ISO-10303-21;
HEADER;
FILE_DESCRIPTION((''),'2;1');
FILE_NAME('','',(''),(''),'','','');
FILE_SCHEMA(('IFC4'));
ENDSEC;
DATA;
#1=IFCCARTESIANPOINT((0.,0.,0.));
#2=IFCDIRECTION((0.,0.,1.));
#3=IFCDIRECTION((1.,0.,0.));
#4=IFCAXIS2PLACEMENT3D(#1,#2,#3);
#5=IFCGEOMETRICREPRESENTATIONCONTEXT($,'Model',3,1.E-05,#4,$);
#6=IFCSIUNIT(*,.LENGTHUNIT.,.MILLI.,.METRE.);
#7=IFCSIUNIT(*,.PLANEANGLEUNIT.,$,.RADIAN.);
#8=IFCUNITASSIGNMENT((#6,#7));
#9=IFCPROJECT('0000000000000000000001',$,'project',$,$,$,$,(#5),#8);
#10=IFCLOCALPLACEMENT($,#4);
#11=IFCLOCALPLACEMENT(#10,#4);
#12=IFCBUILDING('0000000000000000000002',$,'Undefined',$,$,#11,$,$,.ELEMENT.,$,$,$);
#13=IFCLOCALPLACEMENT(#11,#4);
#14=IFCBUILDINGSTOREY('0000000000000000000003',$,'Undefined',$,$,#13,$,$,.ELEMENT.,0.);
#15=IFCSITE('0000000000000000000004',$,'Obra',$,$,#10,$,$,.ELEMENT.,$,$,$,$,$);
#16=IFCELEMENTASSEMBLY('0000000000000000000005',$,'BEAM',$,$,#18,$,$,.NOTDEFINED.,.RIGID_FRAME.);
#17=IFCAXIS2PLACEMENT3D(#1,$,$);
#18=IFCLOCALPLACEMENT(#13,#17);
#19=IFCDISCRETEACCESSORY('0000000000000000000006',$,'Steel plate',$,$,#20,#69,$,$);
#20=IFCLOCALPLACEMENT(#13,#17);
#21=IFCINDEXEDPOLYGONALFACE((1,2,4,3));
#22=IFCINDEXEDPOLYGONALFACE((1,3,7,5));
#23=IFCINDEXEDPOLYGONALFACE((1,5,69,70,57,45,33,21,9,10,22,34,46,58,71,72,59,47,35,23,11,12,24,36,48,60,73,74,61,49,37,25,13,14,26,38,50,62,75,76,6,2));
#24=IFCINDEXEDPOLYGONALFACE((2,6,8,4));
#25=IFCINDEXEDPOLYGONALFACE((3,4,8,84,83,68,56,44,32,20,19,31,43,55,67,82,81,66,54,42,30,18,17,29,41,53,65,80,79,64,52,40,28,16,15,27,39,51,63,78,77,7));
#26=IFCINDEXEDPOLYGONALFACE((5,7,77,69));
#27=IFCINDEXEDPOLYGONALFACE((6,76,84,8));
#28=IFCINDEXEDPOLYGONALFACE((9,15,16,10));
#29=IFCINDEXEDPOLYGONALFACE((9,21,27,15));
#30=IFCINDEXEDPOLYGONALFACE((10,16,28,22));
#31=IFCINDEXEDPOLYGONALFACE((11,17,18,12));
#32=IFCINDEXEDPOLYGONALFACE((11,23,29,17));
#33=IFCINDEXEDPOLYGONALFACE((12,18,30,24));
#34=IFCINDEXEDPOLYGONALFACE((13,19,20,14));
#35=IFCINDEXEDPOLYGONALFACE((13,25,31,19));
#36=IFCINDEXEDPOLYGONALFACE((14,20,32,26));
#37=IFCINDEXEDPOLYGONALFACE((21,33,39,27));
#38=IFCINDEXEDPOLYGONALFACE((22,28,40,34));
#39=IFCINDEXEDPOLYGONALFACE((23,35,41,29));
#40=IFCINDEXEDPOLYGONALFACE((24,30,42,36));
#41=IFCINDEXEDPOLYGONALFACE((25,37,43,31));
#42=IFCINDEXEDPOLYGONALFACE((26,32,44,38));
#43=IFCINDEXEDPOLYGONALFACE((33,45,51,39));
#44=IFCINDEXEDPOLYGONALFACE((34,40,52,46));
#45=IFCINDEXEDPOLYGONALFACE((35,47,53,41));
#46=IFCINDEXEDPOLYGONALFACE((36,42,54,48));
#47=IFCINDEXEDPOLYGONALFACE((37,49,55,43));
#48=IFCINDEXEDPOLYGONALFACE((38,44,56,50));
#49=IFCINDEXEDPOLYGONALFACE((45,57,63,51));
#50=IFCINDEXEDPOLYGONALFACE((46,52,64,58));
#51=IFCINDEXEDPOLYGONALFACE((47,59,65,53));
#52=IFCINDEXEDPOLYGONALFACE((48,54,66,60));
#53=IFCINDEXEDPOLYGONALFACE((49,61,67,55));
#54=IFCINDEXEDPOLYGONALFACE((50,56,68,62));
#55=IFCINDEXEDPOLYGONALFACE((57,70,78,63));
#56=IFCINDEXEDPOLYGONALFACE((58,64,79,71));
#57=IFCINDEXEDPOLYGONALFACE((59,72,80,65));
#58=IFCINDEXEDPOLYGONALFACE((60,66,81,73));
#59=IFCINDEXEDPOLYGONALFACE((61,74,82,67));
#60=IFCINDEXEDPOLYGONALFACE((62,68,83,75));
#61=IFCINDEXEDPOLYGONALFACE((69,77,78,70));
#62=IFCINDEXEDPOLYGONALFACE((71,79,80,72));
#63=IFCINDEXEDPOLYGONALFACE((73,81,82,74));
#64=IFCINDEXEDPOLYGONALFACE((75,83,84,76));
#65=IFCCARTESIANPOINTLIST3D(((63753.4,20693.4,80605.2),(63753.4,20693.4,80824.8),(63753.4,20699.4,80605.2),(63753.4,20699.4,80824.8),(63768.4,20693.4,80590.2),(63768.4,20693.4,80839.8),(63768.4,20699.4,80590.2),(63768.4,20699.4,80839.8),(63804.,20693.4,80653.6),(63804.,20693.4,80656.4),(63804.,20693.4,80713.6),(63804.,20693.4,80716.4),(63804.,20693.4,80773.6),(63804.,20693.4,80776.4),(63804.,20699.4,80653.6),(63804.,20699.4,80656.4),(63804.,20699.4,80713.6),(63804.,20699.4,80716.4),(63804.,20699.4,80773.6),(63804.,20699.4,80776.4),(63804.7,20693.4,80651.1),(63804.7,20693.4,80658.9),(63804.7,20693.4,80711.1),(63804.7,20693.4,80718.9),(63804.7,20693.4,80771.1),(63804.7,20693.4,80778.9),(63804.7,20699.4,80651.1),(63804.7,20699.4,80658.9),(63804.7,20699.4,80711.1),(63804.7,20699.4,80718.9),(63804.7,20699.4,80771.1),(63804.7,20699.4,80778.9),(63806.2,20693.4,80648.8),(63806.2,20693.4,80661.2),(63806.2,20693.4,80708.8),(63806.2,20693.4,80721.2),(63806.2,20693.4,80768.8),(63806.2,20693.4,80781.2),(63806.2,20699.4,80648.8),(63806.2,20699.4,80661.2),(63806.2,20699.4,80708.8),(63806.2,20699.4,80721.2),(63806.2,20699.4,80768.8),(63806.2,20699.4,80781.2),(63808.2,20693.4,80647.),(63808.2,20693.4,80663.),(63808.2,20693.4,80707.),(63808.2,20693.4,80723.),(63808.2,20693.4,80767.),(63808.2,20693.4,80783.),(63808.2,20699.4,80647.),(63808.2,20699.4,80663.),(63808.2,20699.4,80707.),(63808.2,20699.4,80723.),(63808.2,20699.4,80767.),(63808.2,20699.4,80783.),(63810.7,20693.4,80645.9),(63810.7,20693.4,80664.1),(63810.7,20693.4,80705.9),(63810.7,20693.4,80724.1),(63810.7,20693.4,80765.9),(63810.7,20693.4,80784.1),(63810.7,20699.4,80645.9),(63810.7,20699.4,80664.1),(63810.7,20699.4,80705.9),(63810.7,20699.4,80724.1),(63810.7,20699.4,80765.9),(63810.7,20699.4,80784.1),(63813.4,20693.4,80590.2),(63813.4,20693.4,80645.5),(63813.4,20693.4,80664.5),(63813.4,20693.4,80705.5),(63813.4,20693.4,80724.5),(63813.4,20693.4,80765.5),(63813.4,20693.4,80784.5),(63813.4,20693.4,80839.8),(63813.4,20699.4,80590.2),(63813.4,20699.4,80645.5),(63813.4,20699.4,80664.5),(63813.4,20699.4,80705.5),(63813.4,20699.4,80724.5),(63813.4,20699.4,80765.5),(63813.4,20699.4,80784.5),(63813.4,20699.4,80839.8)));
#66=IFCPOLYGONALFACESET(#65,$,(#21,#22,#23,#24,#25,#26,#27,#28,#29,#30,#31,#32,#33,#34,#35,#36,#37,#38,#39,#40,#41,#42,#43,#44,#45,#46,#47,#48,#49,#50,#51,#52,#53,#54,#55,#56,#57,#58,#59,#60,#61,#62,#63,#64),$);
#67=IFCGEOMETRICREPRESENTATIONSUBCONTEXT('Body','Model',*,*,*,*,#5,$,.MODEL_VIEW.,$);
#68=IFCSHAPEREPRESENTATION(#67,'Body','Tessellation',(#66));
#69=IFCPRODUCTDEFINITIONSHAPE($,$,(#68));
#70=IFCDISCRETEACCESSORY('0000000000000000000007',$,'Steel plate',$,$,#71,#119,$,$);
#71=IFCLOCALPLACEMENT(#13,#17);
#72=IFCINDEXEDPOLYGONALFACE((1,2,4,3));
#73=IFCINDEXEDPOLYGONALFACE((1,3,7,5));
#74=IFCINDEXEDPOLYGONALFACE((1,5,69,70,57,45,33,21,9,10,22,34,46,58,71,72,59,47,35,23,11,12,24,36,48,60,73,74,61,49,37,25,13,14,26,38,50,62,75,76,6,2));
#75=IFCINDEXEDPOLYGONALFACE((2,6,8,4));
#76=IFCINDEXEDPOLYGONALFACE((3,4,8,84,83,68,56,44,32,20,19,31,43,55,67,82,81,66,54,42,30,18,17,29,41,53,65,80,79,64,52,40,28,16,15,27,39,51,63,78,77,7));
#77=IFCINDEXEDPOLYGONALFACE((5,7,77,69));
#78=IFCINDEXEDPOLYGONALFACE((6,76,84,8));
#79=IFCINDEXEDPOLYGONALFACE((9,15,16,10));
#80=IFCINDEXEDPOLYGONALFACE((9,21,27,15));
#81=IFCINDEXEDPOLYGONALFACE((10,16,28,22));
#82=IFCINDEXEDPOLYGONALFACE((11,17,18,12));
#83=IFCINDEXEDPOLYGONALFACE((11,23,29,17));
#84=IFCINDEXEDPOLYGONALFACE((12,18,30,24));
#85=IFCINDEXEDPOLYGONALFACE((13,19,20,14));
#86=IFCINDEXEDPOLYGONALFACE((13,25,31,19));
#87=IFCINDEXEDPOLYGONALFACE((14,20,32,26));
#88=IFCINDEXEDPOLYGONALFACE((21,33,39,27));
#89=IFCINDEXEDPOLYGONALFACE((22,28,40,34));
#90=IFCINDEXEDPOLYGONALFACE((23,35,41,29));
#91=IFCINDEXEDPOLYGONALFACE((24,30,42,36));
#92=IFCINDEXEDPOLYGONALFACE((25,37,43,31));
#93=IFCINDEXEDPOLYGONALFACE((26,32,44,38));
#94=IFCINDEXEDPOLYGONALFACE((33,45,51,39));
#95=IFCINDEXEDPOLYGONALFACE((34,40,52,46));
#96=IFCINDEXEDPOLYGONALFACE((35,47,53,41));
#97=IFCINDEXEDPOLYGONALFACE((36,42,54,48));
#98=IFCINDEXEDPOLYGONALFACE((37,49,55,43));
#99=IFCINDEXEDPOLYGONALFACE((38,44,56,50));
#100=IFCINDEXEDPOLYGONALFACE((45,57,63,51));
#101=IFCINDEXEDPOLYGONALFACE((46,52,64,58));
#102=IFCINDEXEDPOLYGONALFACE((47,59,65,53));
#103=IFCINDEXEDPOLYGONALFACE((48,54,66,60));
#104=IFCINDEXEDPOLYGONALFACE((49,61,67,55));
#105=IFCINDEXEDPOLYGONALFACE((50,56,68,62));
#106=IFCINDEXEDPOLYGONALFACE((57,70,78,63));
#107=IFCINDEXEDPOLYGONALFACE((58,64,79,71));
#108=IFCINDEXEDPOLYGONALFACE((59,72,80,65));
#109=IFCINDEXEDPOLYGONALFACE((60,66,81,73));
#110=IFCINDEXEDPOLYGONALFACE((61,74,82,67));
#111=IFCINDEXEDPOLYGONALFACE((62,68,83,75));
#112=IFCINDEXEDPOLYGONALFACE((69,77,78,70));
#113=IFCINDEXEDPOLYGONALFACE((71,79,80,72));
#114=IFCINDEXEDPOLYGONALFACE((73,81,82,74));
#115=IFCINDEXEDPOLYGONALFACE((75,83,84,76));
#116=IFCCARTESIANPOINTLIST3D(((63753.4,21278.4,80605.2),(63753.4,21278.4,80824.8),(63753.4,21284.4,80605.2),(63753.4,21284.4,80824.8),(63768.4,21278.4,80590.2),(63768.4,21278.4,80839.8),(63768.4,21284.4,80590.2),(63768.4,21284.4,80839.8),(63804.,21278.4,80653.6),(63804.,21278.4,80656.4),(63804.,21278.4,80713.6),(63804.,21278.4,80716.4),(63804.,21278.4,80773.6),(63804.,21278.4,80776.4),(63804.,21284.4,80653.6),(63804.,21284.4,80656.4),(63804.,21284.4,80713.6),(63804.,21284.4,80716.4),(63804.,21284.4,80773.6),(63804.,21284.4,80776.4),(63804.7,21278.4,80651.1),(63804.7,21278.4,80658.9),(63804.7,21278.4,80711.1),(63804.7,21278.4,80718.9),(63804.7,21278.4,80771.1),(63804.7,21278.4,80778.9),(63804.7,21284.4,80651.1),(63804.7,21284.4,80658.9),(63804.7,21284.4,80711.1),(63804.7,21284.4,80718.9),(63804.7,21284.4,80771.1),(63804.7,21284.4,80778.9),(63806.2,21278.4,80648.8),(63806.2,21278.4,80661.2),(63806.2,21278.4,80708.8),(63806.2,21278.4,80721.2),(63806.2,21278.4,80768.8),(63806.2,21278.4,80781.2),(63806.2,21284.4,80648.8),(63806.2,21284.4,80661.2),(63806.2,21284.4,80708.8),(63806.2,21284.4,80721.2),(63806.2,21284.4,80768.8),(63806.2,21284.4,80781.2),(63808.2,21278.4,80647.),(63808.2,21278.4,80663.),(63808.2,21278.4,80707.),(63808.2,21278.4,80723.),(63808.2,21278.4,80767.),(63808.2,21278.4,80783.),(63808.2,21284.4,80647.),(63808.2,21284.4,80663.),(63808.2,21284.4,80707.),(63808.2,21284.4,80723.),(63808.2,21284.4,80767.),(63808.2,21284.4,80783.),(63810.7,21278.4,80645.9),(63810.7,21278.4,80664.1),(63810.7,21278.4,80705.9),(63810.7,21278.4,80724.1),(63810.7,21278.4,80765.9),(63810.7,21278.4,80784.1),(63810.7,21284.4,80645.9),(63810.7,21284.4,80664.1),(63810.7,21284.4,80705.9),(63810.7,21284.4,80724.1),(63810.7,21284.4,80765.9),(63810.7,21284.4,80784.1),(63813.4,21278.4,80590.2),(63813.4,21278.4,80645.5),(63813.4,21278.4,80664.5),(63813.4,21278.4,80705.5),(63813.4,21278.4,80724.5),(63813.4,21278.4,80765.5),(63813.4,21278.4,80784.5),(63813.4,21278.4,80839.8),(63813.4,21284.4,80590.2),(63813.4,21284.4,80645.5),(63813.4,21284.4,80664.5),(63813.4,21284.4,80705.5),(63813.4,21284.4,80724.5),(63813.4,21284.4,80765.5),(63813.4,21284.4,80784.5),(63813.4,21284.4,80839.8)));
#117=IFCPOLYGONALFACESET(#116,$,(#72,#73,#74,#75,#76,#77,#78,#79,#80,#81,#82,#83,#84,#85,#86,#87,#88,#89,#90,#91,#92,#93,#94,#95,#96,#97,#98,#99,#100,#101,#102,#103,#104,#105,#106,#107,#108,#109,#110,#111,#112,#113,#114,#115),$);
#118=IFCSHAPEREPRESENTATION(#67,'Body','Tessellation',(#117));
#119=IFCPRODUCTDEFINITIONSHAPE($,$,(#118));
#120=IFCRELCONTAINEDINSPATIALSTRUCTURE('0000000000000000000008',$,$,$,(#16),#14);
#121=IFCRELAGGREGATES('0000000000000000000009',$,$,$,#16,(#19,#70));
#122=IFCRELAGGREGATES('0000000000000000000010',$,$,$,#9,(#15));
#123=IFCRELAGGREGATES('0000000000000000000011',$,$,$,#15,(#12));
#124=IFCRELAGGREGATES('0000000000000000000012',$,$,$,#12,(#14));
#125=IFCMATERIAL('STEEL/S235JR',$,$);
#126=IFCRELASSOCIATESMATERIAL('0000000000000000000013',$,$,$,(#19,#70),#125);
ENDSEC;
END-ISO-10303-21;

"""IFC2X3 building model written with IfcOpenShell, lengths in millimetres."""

from ifc_helpers import new_model, si_unit, frame, origin_with_axes, origin_2d_with_axis, place, context, subcontext, project, spatial, polyline, circle, outline, extrude, source, transform, mapped, material, element, aggregate, save


model = new_model("IFC2X3")

# Units and contexts
model_context = context("Model", 3, precision=1e-05, world=origin_with_axes())
body_context = subcontext(model_context, "Body", "Model", "MODEL_VIEW")
ifc_project = project(units=[si_unit("LENGTHUNIT", "METRE", prefix="MILLI"), si_unit("PLANEANGLEUNIT", "RADIAN")], contexts=[model_context])

# Site, building, storey
site_placement = place(None, origin_with_axes())
site = spatial("IfcSite", under=ifc_project, at=site_placement, Name="Obra", CompositionType="ELEMENT")
building_placement = place(site_placement, origin_with_axes())
building = spatial("IfcBuilding", under=site, at=building_placement, Name="Undefined", CompositionType="ELEMENT")
storey_placement = place(building_placement, origin_with_axes())
storey = spatial("IfcBuildingStorey", under=building, at=storey_placement, Name="Undefined", CompositionType="ELEMENT", Elevation=0.0)

# Shared definitions
ifc_material = material(Name="STEEL/S235JR")

# Shared definitions
shared_shape_1 = source(origin_with_axes(), body_context, "Body", "SweptSolid", [
    extrude(circle(Radius=9.5, at=origin_2d_with_axis()), frame((0.0, -9.4, 0.0), z_axis=(0.0, 1.0, 0.0), x_axis=(1.0, 0.0, 0.0)), (0.0, 0.0, 1.0), 6.2),
])

# Element assembly, discrete accessories, openings
assembly_1_placement = place(storey_placement, origin_with_axes())
assembly_1 = element("IfcElementAssembly", 1, at=assembly_1_placement, inside=storey, Name="BEAM", AssemblyPlace="NOTDEFINED", PredefinedType="RIGID_FRAME")
discrete_accessory_1_placement = place(assembly_1_placement, frame((63813.4, 20696.4, 80590.2), z_axis=(0.0, 1.0, 0.0), x_axis=(-1.0, 0.0, 0.0)))
discrete_accessory_1 = element("IfcDiscreteAccessory", 2, at=discrete_accessory_1_placement, material=ifc_material, Name="Steel plate", context=body_context, shape_type="SweptSolid", body=[
    extrude(outline(polyline([(0.0, 0.0), (45.0, 0.0), (60.0, 15.0), (60.0, 234.6), (45.0, 249.6), (0.0, 249.6), (0.0, 0.0)])), frame((0.0, 0.0, -3.0), z_axis=(0.0, 0.0, 1.0), x_axis=(1.0, 0.0, 0.0)), (0.0, 0.0, 1.0), 6.0),
])
opening_1_placement = place(assembly_1_placement, frame((63763.4, 20702.7, 80850.0), z_axis=(1.0, 0.0, 0.0), x_axis=(0.0, 0.0, -1.0)))
element("IfcOpeningElement", 3, at=opening_1_placement, cuts=discrete_accessory_1, ObjectType="Opening", context=body_context, shape_type="MappedRepresentation", body=[
    mapped(shared_shape_1, transform((75.0, 0.0, 50.0))),
    mapped(shared_shape_1, transform((135.0, 0.0, 50.0))),
    mapped(shared_shape_1, transform((195.0, 0.0, 50.0))),
])
discrete_accessory_2_placement = place(assembly_1_placement, frame((63813.4, 21281.4, 80590.2), z_axis=(0.0, 1.0, 0.0), x_axis=(-1.0, 0.0, 0.0)))
discrete_accessory_2 = element("IfcDiscreteAccessory", 4, at=discrete_accessory_2_placement, material=ifc_material, Name="Steel plate", context=body_context, shape_type="SweptSolid", body=[
    extrude(outline(polyline([(0.0, 0.0), (45.0, 0.0), (60.0, 15.0), (60.0, 234.6), (45.0, 249.6), (0.0, 249.6), (0.0, 0.0)])), frame((0.0, 0.0, -3.0), z_axis=(0.0, 0.0, 1.0), x_axis=(1.0, 0.0, 0.0)), (0.0, 0.0, 1.0), 6.0),
])
opening_2_placement = place(assembly_1_placement, frame((63763.4, 21287.7, 80850.0), z_axis=(1.0, 0.0, 0.0), x_axis=(0.0, 0.0, -1.0)))
element("IfcOpeningElement", 5, at=opening_2_placement, cuts=discrete_accessory_2, ObjectType="Opening", context=body_context, shape_type="MappedRepresentation", body=[
    mapped(shared_shape_1, transform((75.0, 0.0, 50.0))),
    mapped(shared_shape_1, transform((135.0, 0.0, 50.0))),
    mapped(shared_shape_1, transform((195.0, 0.0, 50.0))),
])
aggregate(assembly_1, [discrete_accessory_1, discrete_accessory_2])

save(model, "model.ifc")
